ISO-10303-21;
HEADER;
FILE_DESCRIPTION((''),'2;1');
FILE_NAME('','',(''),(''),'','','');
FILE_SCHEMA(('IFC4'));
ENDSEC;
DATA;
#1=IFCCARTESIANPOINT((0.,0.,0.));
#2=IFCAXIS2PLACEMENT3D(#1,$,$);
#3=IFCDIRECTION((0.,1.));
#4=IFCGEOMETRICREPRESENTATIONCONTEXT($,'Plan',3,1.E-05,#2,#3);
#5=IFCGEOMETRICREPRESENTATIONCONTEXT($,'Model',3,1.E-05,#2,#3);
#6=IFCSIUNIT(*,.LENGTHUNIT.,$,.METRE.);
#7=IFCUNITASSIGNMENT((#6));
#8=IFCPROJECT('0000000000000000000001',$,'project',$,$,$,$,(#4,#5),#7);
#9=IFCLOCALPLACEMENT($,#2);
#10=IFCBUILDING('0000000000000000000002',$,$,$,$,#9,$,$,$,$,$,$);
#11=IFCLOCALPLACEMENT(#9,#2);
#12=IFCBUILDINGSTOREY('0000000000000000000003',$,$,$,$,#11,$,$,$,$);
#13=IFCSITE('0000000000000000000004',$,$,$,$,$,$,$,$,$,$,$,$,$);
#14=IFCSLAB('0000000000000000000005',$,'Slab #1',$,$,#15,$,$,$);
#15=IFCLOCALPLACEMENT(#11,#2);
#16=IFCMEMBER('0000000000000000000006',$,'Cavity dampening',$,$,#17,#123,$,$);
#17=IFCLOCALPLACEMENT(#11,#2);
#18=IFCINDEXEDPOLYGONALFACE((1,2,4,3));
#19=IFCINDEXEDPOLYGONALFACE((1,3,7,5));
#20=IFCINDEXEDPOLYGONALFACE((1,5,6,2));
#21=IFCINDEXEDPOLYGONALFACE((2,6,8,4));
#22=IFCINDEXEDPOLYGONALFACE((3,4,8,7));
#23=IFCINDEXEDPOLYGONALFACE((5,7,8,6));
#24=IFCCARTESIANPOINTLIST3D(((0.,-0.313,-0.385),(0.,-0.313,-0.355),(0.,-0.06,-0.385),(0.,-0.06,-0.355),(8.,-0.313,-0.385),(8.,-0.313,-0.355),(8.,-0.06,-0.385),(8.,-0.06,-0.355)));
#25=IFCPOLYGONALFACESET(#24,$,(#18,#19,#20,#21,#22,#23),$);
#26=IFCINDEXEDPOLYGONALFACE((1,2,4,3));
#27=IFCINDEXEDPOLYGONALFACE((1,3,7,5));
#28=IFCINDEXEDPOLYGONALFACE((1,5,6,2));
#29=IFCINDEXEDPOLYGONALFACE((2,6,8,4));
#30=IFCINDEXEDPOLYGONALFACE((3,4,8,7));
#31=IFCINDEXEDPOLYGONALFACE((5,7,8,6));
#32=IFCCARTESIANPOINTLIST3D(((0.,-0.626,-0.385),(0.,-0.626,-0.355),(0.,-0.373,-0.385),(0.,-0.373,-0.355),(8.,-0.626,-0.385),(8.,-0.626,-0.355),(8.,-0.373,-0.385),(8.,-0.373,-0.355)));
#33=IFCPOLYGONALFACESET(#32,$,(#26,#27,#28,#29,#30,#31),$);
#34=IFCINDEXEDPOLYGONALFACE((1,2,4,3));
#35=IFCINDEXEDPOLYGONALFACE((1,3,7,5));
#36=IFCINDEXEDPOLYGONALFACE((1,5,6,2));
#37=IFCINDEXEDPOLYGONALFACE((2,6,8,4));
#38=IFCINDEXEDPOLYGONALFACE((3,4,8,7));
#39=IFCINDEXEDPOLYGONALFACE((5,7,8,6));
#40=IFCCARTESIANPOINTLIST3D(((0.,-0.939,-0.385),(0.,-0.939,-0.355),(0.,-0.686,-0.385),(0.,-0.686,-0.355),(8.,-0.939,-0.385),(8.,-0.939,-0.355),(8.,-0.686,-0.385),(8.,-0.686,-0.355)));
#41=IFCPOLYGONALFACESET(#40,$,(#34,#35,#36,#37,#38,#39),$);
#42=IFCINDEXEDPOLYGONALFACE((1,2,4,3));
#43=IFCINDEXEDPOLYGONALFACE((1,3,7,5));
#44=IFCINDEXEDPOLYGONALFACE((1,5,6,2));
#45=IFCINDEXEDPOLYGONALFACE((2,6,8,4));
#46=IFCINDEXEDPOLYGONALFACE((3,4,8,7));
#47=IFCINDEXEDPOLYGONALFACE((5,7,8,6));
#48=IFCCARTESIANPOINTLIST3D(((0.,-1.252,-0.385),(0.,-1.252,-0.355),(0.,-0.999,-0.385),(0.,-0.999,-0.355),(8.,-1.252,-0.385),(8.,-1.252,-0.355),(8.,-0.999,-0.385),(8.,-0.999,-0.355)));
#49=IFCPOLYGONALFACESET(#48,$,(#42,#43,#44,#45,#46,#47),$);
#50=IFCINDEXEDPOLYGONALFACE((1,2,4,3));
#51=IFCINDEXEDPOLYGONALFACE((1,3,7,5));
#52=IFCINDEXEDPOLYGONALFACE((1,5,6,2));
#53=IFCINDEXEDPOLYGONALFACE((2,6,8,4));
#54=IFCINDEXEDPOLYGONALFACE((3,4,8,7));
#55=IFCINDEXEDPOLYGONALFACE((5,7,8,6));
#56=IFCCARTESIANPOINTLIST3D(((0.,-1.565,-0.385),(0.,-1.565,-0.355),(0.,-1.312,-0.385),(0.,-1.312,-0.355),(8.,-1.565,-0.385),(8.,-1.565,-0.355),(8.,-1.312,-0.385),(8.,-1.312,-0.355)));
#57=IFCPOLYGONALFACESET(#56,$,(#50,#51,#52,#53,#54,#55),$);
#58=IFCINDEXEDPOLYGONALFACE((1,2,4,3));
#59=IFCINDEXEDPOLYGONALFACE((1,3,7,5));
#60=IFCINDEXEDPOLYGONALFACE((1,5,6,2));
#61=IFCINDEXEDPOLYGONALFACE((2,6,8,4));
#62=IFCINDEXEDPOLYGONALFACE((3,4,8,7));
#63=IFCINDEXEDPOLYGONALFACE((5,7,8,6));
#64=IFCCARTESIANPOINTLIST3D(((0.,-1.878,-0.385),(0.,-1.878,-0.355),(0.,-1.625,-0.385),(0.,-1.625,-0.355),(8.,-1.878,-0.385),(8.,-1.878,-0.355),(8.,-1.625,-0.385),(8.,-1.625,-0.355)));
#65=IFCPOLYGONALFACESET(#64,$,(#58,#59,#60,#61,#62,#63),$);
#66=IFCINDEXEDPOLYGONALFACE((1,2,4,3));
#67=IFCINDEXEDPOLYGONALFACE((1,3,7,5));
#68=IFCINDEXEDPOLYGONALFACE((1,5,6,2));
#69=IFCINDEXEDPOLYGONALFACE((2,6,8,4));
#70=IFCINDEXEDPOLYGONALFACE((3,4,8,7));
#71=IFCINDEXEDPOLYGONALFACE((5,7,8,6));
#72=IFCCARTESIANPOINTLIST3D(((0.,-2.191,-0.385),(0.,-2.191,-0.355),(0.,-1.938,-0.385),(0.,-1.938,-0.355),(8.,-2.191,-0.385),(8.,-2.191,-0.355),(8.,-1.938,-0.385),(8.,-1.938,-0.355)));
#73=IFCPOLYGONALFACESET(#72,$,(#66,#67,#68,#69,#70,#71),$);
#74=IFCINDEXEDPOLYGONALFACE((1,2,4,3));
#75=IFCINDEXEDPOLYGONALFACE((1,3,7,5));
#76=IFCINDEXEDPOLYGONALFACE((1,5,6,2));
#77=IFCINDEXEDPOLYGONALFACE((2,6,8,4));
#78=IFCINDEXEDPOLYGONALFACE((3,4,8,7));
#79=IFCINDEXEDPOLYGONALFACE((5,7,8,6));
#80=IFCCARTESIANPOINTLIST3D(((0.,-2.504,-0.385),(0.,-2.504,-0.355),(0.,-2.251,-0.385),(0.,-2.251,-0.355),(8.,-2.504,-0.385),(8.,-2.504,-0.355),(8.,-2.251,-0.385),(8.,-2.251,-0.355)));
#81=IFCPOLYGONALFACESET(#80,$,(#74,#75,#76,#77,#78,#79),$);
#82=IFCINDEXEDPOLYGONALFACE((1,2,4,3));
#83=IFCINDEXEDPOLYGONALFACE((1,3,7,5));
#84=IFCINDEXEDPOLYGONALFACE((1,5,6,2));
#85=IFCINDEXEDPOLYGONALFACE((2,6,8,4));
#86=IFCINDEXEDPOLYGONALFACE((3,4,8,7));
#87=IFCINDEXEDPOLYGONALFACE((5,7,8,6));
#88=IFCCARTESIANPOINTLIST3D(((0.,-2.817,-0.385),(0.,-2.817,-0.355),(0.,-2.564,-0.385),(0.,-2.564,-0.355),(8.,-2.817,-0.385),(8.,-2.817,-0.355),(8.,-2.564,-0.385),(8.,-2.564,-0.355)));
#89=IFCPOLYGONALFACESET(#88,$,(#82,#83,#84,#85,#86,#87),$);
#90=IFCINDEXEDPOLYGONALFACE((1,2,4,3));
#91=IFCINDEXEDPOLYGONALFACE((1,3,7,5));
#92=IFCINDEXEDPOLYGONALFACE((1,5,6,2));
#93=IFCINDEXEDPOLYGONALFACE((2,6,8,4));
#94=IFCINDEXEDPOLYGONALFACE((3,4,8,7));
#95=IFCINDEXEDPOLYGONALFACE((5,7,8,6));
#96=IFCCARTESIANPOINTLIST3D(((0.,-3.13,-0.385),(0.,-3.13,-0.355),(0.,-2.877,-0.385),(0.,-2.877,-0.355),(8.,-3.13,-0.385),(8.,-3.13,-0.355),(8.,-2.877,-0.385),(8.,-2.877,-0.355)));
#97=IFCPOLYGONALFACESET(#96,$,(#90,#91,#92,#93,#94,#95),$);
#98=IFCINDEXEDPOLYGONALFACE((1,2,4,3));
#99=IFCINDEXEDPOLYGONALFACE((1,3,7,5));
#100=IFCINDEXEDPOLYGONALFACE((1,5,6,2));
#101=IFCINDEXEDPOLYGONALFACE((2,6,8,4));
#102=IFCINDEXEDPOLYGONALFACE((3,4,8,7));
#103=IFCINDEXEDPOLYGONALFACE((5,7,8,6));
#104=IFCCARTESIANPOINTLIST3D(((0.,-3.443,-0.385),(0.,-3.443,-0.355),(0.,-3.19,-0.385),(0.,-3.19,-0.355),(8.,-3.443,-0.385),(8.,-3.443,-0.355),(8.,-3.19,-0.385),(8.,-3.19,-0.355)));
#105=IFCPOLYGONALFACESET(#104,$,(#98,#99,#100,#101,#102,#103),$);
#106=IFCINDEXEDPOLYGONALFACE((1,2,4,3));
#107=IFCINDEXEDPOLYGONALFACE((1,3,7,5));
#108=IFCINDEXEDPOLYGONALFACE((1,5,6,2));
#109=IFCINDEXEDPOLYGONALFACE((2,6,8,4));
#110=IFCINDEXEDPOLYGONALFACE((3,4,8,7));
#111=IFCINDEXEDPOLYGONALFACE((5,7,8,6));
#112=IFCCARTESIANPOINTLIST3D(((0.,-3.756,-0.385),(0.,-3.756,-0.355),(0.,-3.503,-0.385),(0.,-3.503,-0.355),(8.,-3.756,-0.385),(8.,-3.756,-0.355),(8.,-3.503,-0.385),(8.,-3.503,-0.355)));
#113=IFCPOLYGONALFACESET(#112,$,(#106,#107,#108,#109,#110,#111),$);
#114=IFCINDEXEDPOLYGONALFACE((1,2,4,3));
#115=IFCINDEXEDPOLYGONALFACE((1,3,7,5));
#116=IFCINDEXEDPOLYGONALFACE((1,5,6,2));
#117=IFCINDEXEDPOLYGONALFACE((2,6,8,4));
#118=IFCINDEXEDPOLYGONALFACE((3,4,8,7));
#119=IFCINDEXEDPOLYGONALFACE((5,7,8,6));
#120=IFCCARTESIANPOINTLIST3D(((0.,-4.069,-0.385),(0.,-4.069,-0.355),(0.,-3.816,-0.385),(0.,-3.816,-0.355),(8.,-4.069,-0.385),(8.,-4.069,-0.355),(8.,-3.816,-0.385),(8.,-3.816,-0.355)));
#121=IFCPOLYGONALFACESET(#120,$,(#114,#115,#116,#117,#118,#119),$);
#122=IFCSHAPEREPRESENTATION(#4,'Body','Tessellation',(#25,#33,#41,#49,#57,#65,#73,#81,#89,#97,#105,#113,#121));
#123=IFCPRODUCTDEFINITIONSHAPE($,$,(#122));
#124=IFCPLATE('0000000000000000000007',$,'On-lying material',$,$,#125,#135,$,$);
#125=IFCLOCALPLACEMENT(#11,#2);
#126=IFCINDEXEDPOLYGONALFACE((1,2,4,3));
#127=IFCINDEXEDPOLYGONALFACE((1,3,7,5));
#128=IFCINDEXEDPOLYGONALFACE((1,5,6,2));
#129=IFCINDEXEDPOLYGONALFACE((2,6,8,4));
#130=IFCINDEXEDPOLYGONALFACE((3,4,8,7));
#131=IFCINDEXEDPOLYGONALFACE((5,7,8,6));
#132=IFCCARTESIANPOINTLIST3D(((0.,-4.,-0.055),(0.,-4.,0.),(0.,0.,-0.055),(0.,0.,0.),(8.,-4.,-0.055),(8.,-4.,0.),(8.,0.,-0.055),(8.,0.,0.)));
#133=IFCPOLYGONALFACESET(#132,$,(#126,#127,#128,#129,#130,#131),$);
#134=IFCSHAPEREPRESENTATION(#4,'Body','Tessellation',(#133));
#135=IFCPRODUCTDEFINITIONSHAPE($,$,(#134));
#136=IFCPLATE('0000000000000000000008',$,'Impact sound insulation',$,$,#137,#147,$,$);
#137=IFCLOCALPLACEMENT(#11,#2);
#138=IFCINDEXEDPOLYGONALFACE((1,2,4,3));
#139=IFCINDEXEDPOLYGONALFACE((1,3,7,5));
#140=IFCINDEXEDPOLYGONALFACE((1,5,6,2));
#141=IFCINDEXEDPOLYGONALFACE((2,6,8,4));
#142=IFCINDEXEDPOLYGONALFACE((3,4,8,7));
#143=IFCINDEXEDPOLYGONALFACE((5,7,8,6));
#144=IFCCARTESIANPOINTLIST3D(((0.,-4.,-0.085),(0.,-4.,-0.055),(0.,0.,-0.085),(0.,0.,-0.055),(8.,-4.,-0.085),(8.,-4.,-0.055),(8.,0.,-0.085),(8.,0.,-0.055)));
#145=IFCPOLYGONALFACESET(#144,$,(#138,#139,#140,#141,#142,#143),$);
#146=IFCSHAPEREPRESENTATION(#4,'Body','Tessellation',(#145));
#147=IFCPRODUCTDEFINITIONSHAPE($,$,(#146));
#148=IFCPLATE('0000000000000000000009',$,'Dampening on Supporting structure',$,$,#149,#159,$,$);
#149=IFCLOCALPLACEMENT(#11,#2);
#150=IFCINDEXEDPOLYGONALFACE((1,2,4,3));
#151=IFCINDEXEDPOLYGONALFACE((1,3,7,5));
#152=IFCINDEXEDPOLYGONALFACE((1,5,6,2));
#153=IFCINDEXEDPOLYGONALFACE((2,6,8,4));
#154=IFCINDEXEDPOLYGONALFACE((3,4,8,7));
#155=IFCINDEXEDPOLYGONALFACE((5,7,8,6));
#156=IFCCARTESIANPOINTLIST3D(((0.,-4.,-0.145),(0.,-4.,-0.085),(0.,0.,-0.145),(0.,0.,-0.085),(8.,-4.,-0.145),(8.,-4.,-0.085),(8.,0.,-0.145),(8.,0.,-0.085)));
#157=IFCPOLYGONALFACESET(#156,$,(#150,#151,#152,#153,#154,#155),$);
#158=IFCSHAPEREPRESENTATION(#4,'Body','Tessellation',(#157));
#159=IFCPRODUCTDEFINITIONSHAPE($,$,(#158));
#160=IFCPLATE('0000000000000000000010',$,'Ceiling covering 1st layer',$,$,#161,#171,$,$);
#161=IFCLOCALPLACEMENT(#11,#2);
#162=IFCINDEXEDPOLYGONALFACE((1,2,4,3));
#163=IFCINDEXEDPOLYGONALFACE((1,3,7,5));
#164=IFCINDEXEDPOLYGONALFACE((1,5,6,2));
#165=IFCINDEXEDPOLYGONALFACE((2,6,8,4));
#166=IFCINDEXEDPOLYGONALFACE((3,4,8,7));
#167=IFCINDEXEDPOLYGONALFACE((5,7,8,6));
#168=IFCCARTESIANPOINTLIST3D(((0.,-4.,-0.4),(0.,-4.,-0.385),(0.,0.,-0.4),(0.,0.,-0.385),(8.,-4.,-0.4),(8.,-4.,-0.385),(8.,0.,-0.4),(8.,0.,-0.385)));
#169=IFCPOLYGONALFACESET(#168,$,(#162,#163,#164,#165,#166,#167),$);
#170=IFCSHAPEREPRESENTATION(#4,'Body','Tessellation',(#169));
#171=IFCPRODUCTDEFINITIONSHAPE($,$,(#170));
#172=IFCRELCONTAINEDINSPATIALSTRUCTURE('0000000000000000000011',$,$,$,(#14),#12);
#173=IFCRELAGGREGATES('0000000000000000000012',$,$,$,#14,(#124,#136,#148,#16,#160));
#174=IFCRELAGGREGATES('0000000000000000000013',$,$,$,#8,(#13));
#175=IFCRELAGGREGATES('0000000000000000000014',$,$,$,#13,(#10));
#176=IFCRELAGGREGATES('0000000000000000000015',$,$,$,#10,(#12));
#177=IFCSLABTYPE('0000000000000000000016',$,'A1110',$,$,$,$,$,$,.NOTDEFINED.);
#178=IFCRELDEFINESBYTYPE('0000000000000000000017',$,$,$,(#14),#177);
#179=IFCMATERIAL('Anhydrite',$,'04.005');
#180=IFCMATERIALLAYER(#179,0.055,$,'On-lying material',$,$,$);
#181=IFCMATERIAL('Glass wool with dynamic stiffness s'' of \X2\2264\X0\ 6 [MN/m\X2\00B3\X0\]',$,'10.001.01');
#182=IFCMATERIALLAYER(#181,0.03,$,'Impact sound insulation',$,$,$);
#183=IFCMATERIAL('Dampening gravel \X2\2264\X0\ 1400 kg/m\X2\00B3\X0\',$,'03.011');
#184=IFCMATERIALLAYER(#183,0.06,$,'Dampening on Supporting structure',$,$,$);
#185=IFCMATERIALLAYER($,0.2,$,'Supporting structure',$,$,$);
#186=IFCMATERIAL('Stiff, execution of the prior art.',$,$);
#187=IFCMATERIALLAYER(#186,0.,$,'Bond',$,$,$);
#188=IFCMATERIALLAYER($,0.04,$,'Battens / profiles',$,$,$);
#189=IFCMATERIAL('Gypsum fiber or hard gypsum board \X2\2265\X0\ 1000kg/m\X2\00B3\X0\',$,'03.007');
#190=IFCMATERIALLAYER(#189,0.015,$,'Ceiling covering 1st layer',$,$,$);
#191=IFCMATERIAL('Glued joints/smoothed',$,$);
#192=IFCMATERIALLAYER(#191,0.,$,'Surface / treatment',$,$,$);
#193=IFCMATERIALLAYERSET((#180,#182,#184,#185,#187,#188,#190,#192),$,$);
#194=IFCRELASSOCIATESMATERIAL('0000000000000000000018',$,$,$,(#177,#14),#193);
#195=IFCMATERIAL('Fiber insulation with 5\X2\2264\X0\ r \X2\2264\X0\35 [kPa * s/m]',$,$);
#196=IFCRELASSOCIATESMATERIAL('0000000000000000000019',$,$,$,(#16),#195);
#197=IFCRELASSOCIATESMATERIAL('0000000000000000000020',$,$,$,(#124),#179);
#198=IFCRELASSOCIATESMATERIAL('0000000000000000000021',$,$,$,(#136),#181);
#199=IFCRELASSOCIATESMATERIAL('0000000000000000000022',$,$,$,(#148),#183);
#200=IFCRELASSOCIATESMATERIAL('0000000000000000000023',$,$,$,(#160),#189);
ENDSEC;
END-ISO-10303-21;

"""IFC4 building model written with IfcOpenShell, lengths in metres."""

from ifc_helpers import new_model, si_unit, direction, frame, frame_2d, origin, origin_with_axes, place, context, project, spatial, rectangle, extrude, material, layer, layer_set, type_object, element, aggregate, save


model = new_model("IFC4")

# Units and contexts
plan_context = context("Plan", 3, precision=1e-05, world=origin(), true_north=direction((0.0, 1.0)))
model_context = context("Model", 3, precision=1e-05, world=origin(), true_north=direction((0.0, 1.0)))
ifc_project = project(units=[si_unit("LENGTHUNIT", "METRE")], contexts=[plan_context, model_context])

# Site, building, storey
site = spatial("IfcSite", under=ifc_project)
building_placement = place(None, origin())
building = spatial("IfcBuilding", under=site, at=building_placement)
storey_placement = place(building_placement, origin())
storey = spatial("IfcBuildingStorey", under=building, at=storey_placement)

# Slab, member, plates
ifc_material_1 = material(Name="Anhydrite", Category="04.005")
ifc_layer_1 = layer(ifc_material_1, 0.055, Name="On-lying material")
ifc_material_2 = material(Name="Glass wool with dynamic stiffness s' of ≤ 6 [MN/m³]", Category="10.001.01")
ifc_layer_2 = layer(ifc_material_2, 0.03, Name="Impact sound insulation")
ifc_material_3 = material(Name="Dampening gravel ≤ 1400 kg/m³", Category="03.011")
ifc_layer_3 = layer(ifc_material_3, 0.06, Name="Dampening on Supporting structure")
ifc_layer_4 = layer(None, 0.2, Name="Supporting structure")
ifc_material_4 = material(Name="Stiff, execution of the prior art.")
ifc_layer_5 = layer(ifc_material_4, 0.0, Name="Bond")
ifc_layer_6 = layer(None, 0.04, Name="Battens / profiles")
ifc_material_5 = material(Name="Gypsum fiber or hard gypsum board ≥ 1000kg/m³", Category="03.007")
ifc_layer_7 = layer(ifc_material_5, 0.015, Name="Ceiling covering 1st layer")
ifc_material_6 = material(Name="Glued joints/smoothed")
ifc_layer_8 = layer(ifc_material_6, 0.0, Name="Surface / treatment")
ifc_layer_set = layer_set([ifc_layer_1, ifc_layer_2, ifc_layer_3, ifc_layer_4, ifc_layer_5, ifc_layer_6, ifc_layer_7, ifc_layer_8])
slab_type = type_object("IfcSlabType", Name="A1110", PredefinedType="NOTDEFINED", material=ifc_layer_set)
slab_placement = place(None, frame((0.0, 0.0, 0.0), z_axis=(0.0, 0.0, -1.0), x_axis=(1.0, 0.0, 0.0)))
slab = element("IfcSlab", 1, at=slab_placement, inside=storey, type_object=slab_type, material=ifc_layer_set, Name="Slab #1")
ifc_material_7 = material(Name="Fiber insulation with 5≤ r ≤35 [kPa * s/m]")
member_1_placement = place(slab_placement, origin())
member_1 = element("IfcMember", 2, at=member_1_placement, material=ifc_material_7, Name="Cavity dampening", context=plan_context, shape_type="SweptSolid", body=[
    extrude(rectangle(XDim=0.253, YDim=0.03, at=frame_2d((0.1265, 0.015), x_axis=(1.0, 0.0))), frame((0.0, 0.06, 0.355), z_axis=(1.0, 0.0, 0.0), x_axis=(0.0, 1.0, 0.0)), (0.0, 0.0, 1.0), 8.0),
    extrude(rectangle(XDim=0.253, YDim=0.03, at=frame_2d((0.1265, 0.015), x_axis=(1.0, 0.0))), frame((0.0, 0.373, 0.355), z_axis=(1.0, 0.0, 0.0), x_axis=(0.0, 1.0, 0.0)), (0.0, 0.0, 1.0), 8.0),
    extrude(rectangle(XDim=0.253, YDim=0.03, at=frame_2d((0.1265, 0.015), x_axis=(1.0, 0.0))), frame((0.0, 0.686, 0.355), z_axis=(1.0, 0.0, 0.0), x_axis=(0.0, 1.0, 0.0)), (0.0, 0.0, 1.0), 8.0),
    extrude(rectangle(XDim=0.253, YDim=0.03, at=frame_2d((0.1265, 0.015), x_axis=(1.0, 0.0))), frame((0.0, 0.999, 0.355), z_axis=(1.0, 0.0, 0.0), x_axis=(0.0, 1.0, 0.0)), (0.0, 0.0, 1.0), 8.0),
    extrude(rectangle(XDim=0.253, YDim=0.03, at=frame_2d((0.1265, 0.015), x_axis=(1.0, 0.0))), frame((0.0, 1.312, 0.355), z_axis=(1.0, 0.0, 0.0), x_axis=(0.0, 1.0, 0.0)), (0.0, 0.0, 1.0), 8.0),
    extrude(rectangle(XDim=0.253, YDim=0.03, at=frame_2d((0.1265, 0.015), x_axis=(1.0, 0.0))), frame((0.0, 1.625, 0.355), z_axis=(1.0, 0.0, 0.0), x_axis=(0.0, 1.0, 0.0)), (0.0, 0.0, 1.0), 8.0),
    extrude(rectangle(XDim=0.253, YDim=0.03, at=frame_2d((0.1265, 0.015), x_axis=(1.0, 0.0))), frame((0.0, 1.938, 0.355), z_axis=(1.0, 0.0, 0.0), x_axis=(0.0, 1.0, 0.0)), (0.0, 0.0, 1.0), 8.0),
    extrude(rectangle(XDim=0.253, YDim=0.03, at=frame_2d((0.1265, 0.015), x_axis=(1.0, 0.0))), frame((0.0, 2.251, 0.355), z_axis=(1.0, 0.0, 0.0), x_axis=(0.0, 1.0, 0.0)), (0.0, 0.0, 1.0), 8.0),
    extrude(rectangle(XDim=0.253, YDim=0.03, at=frame_2d((0.1265, 0.015), x_axis=(1.0, 0.0))), frame((0.0, 2.564, 0.355), z_axis=(1.0, 0.0, 0.0), x_axis=(0.0, 1.0, 0.0)), (0.0, 0.0, 1.0), 8.0),
    extrude(rectangle(XDim=0.253, YDim=0.03, at=frame_2d((0.1265, 0.015), x_axis=(1.0, 0.0))), frame((0.0, 2.877, 0.355), z_axis=(1.0, 0.0, 0.0), x_axis=(0.0, 1.0, 0.0)), (0.0, 0.0, 1.0), 8.0),
    extrude(rectangle(XDim=0.253, YDim=0.03, at=frame_2d((0.1265, 0.015), x_axis=(1.0, 0.0))), frame((0.0, 3.19, 0.355), z_axis=(1.0, 0.0, 0.0), x_axis=(0.0, 1.0, 0.0)), (0.0, 0.0, 1.0), 8.0),
    extrude(rectangle(XDim=0.253, YDim=0.03, at=frame_2d((0.1265, 0.015), x_axis=(1.0, 0.0))), frame((0.0, 3.503, 0.355), z_axis=(1.0, 0.0, 0.0), x_axis=(0.0, 1.0, 0.0)), (0.0, 0.0, 1.0), 8.0),
    extrude(rectangle(XDim=0.253, YDim=0.03, at=frame_2d((0.1265, 0.015), x_axis=(1.0, 0.0))), frame((0.0, 3.816, 0.355), z_axis=(1.0, 0.0, 0.0), x_axis=(0.0, 1.0, 0.0)), (0.0, 0.0, 1.0), 8.0),
])
plate_1_placement = place(slab_placement, origin())
plate_1 = element("IfcPlate", 3, at=plate_1_placement, material=ifc_material_1, Name="On-lying material", context=plan_context, shape_type="SweptSolid", body=[
    extrude(rectangle(XDim=8.0, YDim=4.0, at=frame_2d((4.0, 2.0), x_axis=(1.0, 0.0))), origin_with_axes(), (0.0, 0.0, 1.0), 0.055),
])
plate_2_placement = place(slab_placement, origin())
plate_2 = element("IfcPlate", 4, at=plate_2_placement, material=ifc_material_2, Name="Impact sound insulation", context=plan_context, shape_type="SweptSolid", body=[
    extrude(rectangle(XDim=8.0, YDim=4.0, at=frame_2d((4.0, 2.0), x_axis=(1.0, 0.0))), frame((0.0, 0.0, 0.055), z_axis=(0.0, 0.0, 1.0), x_axis=(1.0, 0.0, 0.0)), (0.0, 0.0, 1.0), 0.03),
])
plate_3_placement = place(slab_placement, origin())
plate_3 = element("IfcPlate", 5, at=plate_3_placement, material=ifc_material_3, Name="Dampening on Supporting structure", context=plan_context, shape_type="SweptSolid", body=[
    extrude(rectangle(XDim=8.0, YDim=4.0, at=frame_2d((4.0, 2.0), x_axis=(1.0, 0.0))), frame((0.0, 0.0, 0.085), z_axis=(0.0, 0.0, 1.0), x_axis=(1.0, 0.0, 0.0)), (0.0, 0.0, 1.0), 0.06),
])
plate_4_placement = place(slab_placement, origin())
plate_4 = element("IfcPlate", 6, at=plate_4_placement, material=ifc_material_5, Name="Ceiling covering 1st layer", context=plan_context, shape_type="SweptSolid", body=[
    extrude(rectangle(XDim=8.0, YDim=4.0, at=frame_2d((4.0, 2.0), x_axis=(1.0, 0.0))), frame((0.0, 0.0, 0.385), z_axis=(0.0, 0.0, 1.0), x_axis=(1.0, 0.0, 0.0)), (0.0, 0.0, 1.0), 0.015),
])
aggregate(slab, [plate_1, plate_2, plate_3, member_1, plate_4])

save(model, "model.ifc")
